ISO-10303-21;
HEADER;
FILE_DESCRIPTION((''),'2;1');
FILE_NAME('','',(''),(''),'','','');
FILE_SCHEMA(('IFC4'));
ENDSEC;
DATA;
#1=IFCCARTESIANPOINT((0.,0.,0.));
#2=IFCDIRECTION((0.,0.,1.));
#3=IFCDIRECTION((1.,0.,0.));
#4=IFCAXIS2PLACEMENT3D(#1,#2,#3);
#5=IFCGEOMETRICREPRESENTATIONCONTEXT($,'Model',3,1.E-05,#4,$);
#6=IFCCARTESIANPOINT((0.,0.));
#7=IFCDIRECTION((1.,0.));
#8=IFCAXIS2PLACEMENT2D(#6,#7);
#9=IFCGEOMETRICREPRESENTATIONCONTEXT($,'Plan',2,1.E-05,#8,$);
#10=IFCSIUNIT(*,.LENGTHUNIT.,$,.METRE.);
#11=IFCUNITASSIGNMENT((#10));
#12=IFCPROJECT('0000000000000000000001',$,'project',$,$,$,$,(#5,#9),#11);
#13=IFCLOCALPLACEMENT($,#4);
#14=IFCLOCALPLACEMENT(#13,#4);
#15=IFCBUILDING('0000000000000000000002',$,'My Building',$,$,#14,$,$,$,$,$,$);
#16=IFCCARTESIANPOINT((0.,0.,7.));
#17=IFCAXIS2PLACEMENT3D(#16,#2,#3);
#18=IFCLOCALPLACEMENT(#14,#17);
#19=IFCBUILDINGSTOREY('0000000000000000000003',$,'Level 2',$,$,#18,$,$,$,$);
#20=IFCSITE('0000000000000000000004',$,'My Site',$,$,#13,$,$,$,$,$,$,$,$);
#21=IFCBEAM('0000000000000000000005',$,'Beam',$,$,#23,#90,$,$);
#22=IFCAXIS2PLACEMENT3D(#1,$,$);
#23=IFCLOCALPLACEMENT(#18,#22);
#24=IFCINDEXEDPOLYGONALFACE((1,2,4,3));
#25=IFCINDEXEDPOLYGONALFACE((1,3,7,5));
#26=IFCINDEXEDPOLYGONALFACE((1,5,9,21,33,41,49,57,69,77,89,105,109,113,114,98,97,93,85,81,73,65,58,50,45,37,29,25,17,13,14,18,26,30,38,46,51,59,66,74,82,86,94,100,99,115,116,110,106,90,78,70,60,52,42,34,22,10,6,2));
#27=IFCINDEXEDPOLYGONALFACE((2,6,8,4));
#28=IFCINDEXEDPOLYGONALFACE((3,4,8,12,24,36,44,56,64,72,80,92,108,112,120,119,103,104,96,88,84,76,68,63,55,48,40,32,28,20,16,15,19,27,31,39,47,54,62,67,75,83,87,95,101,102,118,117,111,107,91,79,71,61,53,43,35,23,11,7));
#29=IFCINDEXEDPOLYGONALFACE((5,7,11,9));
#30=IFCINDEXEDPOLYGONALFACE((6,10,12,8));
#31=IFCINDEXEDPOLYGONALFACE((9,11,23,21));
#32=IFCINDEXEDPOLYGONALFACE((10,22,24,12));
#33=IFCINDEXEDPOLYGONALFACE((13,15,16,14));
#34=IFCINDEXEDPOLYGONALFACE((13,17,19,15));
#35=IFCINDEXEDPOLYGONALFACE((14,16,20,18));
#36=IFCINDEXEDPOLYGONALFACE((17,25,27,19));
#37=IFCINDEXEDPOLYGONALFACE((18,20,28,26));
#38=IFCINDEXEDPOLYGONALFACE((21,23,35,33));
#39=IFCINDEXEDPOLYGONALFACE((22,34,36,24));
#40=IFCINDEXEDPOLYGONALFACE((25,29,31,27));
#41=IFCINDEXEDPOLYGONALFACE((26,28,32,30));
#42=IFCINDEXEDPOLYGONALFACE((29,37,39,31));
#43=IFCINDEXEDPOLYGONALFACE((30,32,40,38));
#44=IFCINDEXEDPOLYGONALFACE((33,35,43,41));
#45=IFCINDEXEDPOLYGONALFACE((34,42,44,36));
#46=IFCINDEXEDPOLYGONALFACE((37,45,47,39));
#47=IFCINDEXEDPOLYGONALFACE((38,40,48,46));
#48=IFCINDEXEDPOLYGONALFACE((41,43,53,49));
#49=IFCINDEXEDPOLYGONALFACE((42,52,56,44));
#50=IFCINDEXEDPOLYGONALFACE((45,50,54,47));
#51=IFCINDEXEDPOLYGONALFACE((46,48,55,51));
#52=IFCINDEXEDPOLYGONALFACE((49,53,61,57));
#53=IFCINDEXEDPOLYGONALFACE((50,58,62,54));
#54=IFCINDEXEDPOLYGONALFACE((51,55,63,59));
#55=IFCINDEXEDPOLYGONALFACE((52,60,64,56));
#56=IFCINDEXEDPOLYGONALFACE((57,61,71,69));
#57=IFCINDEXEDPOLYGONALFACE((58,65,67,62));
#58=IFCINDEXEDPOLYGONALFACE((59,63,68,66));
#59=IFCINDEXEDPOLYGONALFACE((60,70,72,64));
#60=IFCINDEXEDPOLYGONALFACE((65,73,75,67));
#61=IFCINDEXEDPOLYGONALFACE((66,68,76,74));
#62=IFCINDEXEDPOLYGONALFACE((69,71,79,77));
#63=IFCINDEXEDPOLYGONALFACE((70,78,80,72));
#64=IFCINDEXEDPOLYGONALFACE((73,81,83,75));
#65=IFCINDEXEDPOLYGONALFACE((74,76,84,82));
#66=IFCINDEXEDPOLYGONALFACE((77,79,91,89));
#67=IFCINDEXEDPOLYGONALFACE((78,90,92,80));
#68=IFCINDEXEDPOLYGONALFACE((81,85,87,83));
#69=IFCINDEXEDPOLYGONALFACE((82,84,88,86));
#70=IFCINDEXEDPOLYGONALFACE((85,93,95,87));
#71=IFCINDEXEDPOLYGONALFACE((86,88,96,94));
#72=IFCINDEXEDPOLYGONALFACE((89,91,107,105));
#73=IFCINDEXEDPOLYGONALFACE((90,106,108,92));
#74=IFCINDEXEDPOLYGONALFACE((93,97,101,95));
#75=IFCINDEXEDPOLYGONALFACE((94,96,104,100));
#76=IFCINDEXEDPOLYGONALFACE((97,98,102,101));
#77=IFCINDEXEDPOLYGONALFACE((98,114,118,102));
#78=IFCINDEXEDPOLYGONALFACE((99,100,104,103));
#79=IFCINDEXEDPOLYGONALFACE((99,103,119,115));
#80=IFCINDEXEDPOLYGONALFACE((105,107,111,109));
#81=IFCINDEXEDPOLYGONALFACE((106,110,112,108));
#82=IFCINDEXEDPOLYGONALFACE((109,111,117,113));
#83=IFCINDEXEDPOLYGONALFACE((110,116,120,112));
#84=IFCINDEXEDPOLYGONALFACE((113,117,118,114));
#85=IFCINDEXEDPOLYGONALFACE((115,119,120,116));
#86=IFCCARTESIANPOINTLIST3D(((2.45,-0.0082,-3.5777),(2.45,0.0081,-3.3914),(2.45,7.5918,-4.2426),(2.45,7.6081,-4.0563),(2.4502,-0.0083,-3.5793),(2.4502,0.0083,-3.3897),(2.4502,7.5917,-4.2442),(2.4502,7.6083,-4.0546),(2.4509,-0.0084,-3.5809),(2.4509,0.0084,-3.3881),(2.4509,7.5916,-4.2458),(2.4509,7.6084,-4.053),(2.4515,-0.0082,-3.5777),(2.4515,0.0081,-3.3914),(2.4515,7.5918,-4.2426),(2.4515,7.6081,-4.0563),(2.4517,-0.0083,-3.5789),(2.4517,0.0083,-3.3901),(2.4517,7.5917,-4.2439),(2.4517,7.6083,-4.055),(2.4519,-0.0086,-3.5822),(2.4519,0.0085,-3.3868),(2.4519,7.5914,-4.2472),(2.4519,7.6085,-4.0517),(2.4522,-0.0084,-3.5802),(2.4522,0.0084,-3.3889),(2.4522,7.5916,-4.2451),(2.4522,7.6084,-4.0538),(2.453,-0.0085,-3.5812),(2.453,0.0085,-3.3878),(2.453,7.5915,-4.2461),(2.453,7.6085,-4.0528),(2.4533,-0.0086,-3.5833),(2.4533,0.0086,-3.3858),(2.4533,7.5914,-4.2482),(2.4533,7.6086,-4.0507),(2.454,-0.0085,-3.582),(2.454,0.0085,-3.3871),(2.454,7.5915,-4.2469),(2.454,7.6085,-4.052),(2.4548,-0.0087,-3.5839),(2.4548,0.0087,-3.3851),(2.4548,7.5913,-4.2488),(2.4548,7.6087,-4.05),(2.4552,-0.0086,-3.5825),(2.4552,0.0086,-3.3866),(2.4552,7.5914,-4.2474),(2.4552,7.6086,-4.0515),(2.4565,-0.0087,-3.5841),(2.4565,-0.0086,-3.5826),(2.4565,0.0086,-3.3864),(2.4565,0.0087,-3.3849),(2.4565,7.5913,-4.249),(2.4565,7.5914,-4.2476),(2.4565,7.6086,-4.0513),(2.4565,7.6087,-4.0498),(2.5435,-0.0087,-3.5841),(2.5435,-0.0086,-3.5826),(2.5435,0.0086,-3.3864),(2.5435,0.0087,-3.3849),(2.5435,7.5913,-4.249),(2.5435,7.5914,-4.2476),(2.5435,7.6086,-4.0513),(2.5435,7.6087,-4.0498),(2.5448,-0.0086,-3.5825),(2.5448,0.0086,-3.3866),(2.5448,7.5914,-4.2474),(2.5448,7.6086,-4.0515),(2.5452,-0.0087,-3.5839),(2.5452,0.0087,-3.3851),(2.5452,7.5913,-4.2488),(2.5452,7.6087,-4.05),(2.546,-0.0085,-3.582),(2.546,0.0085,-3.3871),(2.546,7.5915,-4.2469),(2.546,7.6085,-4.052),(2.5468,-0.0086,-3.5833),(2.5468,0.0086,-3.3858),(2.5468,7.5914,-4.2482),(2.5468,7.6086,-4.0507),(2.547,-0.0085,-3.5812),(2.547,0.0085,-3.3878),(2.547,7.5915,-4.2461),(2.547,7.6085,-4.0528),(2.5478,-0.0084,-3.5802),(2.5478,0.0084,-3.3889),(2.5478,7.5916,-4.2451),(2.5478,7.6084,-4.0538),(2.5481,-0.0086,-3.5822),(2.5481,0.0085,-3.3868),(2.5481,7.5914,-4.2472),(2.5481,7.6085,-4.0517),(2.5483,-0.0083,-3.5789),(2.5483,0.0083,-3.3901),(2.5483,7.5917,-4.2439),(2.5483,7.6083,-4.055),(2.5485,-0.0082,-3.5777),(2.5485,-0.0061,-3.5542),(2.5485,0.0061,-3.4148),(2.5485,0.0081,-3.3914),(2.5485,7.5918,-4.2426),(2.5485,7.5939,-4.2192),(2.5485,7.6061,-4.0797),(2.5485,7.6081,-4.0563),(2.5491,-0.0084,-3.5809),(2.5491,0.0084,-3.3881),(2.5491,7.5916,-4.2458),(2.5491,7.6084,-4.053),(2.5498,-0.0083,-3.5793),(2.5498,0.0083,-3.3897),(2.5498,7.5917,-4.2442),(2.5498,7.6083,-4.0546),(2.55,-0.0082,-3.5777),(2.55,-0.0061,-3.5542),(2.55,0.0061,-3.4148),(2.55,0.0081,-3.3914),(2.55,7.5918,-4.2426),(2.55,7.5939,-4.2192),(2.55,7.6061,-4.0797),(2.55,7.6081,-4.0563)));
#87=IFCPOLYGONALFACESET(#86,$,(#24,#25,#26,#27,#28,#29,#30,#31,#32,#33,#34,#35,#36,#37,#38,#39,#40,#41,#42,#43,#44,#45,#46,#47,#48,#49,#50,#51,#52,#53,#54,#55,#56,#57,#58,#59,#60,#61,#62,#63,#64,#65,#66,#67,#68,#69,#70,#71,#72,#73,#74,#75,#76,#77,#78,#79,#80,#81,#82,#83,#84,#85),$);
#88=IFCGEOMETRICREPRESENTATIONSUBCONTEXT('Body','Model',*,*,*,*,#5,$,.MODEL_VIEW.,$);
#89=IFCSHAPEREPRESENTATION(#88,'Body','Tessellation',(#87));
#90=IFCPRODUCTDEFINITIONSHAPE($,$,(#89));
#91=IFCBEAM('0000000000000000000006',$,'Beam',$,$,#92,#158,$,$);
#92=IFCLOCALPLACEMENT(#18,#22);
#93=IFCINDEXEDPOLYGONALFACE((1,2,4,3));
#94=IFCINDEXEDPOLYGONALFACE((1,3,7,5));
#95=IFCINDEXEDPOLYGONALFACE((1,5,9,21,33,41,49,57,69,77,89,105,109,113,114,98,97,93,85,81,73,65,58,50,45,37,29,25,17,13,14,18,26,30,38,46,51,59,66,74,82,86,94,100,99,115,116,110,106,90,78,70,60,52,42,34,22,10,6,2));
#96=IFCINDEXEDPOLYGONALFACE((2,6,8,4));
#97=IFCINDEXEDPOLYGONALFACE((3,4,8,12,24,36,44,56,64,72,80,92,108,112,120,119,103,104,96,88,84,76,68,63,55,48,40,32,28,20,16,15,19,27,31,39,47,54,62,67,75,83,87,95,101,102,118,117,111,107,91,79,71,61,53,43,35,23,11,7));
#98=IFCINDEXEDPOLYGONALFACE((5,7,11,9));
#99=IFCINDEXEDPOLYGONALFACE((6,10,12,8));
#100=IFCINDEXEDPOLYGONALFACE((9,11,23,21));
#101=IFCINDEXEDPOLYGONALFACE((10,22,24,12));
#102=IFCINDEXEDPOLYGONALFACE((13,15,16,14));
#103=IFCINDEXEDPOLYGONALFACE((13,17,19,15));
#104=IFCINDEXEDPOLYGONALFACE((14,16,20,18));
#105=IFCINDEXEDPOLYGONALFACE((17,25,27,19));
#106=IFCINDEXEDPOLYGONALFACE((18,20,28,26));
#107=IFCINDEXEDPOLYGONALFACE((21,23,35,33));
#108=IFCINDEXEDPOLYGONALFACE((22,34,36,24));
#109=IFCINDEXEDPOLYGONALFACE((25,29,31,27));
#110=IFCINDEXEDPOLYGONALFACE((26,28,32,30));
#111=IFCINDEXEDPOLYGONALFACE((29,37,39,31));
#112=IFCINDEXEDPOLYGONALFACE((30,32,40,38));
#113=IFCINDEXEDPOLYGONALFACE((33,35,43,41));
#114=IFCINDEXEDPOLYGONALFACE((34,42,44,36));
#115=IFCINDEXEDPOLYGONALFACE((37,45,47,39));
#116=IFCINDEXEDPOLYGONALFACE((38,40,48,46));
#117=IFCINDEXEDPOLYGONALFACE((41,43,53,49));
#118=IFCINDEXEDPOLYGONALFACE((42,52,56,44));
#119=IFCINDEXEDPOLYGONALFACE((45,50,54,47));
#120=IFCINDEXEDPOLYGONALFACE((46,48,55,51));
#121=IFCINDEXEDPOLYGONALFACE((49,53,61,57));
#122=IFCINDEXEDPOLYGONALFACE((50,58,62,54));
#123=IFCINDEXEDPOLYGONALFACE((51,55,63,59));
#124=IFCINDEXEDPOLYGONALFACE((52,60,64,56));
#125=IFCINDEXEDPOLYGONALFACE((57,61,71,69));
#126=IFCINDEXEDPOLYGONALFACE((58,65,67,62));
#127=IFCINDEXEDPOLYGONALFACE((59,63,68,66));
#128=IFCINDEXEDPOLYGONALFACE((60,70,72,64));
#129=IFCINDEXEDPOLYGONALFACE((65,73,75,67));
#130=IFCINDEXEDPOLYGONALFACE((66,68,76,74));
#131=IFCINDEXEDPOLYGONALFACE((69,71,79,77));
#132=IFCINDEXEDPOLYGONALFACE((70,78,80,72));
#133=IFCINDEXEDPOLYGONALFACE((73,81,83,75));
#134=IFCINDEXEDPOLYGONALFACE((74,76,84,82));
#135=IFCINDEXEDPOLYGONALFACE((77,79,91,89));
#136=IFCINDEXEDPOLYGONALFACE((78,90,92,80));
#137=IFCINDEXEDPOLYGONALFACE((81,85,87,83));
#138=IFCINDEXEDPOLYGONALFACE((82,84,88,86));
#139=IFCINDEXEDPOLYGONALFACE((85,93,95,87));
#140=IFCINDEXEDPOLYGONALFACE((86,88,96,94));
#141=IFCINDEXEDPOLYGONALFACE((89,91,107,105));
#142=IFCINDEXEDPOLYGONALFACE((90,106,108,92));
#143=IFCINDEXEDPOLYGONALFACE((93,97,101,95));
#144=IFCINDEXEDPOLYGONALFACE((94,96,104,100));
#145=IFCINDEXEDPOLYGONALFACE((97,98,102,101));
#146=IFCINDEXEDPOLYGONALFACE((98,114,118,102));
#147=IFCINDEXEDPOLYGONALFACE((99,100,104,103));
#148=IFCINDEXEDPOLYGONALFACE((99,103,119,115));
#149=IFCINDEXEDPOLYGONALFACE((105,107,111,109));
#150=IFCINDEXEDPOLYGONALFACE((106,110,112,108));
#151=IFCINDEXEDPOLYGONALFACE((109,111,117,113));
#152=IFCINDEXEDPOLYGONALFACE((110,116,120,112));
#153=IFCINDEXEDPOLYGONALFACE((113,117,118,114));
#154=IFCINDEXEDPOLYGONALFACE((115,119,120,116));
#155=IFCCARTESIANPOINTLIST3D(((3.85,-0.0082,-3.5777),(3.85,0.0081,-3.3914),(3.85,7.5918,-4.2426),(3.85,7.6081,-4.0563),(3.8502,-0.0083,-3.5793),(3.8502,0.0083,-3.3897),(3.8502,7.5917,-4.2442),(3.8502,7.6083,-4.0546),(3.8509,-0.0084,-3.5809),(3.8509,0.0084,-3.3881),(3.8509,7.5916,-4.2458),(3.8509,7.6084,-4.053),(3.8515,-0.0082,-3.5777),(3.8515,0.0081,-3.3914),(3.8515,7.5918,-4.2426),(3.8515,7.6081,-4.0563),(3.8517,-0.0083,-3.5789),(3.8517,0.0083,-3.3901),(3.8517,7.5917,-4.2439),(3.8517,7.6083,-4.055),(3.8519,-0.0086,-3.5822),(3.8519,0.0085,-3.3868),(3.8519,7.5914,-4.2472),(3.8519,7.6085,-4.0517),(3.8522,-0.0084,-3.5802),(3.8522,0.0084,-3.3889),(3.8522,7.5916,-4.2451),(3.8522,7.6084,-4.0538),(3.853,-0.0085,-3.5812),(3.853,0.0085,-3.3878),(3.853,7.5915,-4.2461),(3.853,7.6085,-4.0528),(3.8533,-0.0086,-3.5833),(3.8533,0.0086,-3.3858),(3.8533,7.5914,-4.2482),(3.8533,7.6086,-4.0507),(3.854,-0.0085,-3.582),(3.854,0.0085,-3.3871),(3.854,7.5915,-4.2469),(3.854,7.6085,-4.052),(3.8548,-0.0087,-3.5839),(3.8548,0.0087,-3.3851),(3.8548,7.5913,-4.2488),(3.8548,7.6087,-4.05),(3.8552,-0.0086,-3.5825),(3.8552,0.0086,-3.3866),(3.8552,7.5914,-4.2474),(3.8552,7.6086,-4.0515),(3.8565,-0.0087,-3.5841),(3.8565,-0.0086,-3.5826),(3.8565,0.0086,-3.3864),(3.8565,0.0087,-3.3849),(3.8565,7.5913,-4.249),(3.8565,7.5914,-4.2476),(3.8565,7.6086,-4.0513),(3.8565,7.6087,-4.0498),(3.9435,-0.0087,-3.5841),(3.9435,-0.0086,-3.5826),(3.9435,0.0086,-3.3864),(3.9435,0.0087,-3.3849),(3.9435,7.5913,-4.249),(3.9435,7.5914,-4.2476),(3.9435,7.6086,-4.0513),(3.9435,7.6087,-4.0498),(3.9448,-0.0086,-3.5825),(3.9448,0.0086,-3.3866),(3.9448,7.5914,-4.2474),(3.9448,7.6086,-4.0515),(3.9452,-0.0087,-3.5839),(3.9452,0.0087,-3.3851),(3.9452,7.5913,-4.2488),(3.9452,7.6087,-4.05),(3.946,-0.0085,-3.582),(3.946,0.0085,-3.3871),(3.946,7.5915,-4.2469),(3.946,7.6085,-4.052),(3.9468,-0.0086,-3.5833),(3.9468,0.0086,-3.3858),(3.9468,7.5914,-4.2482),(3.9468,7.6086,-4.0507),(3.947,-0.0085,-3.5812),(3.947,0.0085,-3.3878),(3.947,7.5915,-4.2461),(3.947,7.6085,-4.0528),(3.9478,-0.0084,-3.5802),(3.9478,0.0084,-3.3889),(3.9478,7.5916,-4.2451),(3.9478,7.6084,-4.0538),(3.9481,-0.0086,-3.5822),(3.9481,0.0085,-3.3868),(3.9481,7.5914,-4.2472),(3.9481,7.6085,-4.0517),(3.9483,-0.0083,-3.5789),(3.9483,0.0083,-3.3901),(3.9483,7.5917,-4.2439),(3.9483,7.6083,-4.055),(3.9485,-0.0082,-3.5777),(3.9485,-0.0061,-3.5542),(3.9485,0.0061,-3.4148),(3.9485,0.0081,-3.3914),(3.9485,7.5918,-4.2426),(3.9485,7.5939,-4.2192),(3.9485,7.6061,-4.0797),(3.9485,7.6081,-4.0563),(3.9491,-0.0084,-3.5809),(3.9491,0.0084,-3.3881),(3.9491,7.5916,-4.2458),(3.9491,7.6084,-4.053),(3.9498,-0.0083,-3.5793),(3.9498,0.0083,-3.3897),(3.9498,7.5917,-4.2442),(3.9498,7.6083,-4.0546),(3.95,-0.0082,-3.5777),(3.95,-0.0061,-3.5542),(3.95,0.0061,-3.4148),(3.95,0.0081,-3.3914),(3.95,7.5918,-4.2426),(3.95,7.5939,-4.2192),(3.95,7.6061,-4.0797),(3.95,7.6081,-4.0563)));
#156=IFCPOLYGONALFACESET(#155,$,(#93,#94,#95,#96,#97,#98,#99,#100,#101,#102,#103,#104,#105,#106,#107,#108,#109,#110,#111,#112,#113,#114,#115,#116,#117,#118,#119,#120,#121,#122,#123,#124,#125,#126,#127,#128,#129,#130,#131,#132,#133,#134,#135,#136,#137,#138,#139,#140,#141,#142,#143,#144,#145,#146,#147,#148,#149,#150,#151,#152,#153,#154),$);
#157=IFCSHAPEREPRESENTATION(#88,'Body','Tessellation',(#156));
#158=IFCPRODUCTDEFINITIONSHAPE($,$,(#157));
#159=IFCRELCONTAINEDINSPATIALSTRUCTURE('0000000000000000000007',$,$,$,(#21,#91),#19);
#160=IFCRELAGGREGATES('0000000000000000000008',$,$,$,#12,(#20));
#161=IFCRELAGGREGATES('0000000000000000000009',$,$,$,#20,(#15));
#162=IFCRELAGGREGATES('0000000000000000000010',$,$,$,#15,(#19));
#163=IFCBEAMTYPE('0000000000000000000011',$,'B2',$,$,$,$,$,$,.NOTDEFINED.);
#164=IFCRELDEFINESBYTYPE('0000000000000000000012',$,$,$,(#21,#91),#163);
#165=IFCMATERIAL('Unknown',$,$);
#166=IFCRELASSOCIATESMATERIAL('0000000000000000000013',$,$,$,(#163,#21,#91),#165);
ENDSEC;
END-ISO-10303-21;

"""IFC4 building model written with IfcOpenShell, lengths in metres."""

from ifc_helpers import new_model, si_unit, frame, origin_with_axes, origin_2d_with_axis, place, context, subcontext, project, spatial, c_section, extrude, material, material_profile, profile_set, profile_usage, type_object, element, save


model = new_model("IFC4")

# Units and contexts
model_context = context("Model", 3, precision=1e-05, world=origin_with_axes())
plan_context = context("Plan", 2, precision=1e-05, world=origin_2d_with_axis())
body_context = subcontext(model_context, "Body", "Model", "MODEL_VIEW")
ifc_project = project(units=[si_unit("LENGTHUNIT", "METRE")], contexts=[model_context, plan_context])

# Site, building, storey
site_placement = place(None, origin_with_axes())
site = spatial("IfcSite", under=ifc_project, at=site_placement, Name="My Site")
building_placement = place(site_placement, origin_with_axes())
building = spatial("IfcBuilding", under=site, at=building_placement, Name="My Building")
storey_placement = place(building_placement, frame((0.0, 0.0, 7.0), z_axis=(0.0, 0.0, 1.0), x_axis=(1.0, 0.0, 0.0)))
storey = spatial("IfcBuildingStorey", under=building, at=storey_placement, Name="Level 2")

# Shared definitions
ifc_material = material(Name="Unknown")

# Beams
ifc_material_profile_1 = material_profile(ifc_material, c_section(Depth=0.2, Width=0.1, WallThickness=0.0015, Girth=0.03, InternalFilletRadius=0.005))
ifc_profile_set_1 = profile_set([ifc_material_profile_1])
beam_type_1 = type_object("IfcBeamType", Name="B2", PredefinedType="NOTDEFINED", material=ifc_profile_set_1)
ifc_profile_usage_1 = profile_usage(ifc_profile_set_1, cardinal=5)
beam_1_placement = place(storey_placement, frame((2.5, 7.6, -4.1494), z_axis=(0.0, -0.996195, 0.087156), x_axis=(1.0, 0.0, 0.0)))
element("IfcBeam", 1, at=beam_1_placement, inside=storey, type_object=beam_type_1, material=ifc_profile_usage_1, Name="Beam", context=body_context, shape_type="SweptSolid", body=[
    extrude(c_section(Depth=0.2, Width=0.1, WallThickness=0.0015, Girth=0.03, InternalFilletRadius=0.005), origin_with_axes(), (0.0, 0.0, 1.0), 7.629),
])
ifc_profile_usage_2 = profile_usage(ifc_profile_set_1, cardinal=5)
beam_2_placement = place(storey_placement, frame((3.9, 7.6, -4.1494), z_axis=(0.0, -0.996195, 0.087156), x_axis=(1.0, 0.0, 0.0)))
element("IfcBeam", 2, at=beam_2_placement, inside=storey, type_object=beam_type_1, material=ifc_profile_usage_2, Name="Beam", context=body_context, shape_type="SweptSolid", body=[
    extrude(c_section(Depth=0.2, Width=0.1, WallThickness=0.0015, Girth=0.03, InternalFilletRadius=0.005), origin_with_axes(), (0.0, 0.0, 1.0), 7.629),
])

save(model, "model.ifc")
